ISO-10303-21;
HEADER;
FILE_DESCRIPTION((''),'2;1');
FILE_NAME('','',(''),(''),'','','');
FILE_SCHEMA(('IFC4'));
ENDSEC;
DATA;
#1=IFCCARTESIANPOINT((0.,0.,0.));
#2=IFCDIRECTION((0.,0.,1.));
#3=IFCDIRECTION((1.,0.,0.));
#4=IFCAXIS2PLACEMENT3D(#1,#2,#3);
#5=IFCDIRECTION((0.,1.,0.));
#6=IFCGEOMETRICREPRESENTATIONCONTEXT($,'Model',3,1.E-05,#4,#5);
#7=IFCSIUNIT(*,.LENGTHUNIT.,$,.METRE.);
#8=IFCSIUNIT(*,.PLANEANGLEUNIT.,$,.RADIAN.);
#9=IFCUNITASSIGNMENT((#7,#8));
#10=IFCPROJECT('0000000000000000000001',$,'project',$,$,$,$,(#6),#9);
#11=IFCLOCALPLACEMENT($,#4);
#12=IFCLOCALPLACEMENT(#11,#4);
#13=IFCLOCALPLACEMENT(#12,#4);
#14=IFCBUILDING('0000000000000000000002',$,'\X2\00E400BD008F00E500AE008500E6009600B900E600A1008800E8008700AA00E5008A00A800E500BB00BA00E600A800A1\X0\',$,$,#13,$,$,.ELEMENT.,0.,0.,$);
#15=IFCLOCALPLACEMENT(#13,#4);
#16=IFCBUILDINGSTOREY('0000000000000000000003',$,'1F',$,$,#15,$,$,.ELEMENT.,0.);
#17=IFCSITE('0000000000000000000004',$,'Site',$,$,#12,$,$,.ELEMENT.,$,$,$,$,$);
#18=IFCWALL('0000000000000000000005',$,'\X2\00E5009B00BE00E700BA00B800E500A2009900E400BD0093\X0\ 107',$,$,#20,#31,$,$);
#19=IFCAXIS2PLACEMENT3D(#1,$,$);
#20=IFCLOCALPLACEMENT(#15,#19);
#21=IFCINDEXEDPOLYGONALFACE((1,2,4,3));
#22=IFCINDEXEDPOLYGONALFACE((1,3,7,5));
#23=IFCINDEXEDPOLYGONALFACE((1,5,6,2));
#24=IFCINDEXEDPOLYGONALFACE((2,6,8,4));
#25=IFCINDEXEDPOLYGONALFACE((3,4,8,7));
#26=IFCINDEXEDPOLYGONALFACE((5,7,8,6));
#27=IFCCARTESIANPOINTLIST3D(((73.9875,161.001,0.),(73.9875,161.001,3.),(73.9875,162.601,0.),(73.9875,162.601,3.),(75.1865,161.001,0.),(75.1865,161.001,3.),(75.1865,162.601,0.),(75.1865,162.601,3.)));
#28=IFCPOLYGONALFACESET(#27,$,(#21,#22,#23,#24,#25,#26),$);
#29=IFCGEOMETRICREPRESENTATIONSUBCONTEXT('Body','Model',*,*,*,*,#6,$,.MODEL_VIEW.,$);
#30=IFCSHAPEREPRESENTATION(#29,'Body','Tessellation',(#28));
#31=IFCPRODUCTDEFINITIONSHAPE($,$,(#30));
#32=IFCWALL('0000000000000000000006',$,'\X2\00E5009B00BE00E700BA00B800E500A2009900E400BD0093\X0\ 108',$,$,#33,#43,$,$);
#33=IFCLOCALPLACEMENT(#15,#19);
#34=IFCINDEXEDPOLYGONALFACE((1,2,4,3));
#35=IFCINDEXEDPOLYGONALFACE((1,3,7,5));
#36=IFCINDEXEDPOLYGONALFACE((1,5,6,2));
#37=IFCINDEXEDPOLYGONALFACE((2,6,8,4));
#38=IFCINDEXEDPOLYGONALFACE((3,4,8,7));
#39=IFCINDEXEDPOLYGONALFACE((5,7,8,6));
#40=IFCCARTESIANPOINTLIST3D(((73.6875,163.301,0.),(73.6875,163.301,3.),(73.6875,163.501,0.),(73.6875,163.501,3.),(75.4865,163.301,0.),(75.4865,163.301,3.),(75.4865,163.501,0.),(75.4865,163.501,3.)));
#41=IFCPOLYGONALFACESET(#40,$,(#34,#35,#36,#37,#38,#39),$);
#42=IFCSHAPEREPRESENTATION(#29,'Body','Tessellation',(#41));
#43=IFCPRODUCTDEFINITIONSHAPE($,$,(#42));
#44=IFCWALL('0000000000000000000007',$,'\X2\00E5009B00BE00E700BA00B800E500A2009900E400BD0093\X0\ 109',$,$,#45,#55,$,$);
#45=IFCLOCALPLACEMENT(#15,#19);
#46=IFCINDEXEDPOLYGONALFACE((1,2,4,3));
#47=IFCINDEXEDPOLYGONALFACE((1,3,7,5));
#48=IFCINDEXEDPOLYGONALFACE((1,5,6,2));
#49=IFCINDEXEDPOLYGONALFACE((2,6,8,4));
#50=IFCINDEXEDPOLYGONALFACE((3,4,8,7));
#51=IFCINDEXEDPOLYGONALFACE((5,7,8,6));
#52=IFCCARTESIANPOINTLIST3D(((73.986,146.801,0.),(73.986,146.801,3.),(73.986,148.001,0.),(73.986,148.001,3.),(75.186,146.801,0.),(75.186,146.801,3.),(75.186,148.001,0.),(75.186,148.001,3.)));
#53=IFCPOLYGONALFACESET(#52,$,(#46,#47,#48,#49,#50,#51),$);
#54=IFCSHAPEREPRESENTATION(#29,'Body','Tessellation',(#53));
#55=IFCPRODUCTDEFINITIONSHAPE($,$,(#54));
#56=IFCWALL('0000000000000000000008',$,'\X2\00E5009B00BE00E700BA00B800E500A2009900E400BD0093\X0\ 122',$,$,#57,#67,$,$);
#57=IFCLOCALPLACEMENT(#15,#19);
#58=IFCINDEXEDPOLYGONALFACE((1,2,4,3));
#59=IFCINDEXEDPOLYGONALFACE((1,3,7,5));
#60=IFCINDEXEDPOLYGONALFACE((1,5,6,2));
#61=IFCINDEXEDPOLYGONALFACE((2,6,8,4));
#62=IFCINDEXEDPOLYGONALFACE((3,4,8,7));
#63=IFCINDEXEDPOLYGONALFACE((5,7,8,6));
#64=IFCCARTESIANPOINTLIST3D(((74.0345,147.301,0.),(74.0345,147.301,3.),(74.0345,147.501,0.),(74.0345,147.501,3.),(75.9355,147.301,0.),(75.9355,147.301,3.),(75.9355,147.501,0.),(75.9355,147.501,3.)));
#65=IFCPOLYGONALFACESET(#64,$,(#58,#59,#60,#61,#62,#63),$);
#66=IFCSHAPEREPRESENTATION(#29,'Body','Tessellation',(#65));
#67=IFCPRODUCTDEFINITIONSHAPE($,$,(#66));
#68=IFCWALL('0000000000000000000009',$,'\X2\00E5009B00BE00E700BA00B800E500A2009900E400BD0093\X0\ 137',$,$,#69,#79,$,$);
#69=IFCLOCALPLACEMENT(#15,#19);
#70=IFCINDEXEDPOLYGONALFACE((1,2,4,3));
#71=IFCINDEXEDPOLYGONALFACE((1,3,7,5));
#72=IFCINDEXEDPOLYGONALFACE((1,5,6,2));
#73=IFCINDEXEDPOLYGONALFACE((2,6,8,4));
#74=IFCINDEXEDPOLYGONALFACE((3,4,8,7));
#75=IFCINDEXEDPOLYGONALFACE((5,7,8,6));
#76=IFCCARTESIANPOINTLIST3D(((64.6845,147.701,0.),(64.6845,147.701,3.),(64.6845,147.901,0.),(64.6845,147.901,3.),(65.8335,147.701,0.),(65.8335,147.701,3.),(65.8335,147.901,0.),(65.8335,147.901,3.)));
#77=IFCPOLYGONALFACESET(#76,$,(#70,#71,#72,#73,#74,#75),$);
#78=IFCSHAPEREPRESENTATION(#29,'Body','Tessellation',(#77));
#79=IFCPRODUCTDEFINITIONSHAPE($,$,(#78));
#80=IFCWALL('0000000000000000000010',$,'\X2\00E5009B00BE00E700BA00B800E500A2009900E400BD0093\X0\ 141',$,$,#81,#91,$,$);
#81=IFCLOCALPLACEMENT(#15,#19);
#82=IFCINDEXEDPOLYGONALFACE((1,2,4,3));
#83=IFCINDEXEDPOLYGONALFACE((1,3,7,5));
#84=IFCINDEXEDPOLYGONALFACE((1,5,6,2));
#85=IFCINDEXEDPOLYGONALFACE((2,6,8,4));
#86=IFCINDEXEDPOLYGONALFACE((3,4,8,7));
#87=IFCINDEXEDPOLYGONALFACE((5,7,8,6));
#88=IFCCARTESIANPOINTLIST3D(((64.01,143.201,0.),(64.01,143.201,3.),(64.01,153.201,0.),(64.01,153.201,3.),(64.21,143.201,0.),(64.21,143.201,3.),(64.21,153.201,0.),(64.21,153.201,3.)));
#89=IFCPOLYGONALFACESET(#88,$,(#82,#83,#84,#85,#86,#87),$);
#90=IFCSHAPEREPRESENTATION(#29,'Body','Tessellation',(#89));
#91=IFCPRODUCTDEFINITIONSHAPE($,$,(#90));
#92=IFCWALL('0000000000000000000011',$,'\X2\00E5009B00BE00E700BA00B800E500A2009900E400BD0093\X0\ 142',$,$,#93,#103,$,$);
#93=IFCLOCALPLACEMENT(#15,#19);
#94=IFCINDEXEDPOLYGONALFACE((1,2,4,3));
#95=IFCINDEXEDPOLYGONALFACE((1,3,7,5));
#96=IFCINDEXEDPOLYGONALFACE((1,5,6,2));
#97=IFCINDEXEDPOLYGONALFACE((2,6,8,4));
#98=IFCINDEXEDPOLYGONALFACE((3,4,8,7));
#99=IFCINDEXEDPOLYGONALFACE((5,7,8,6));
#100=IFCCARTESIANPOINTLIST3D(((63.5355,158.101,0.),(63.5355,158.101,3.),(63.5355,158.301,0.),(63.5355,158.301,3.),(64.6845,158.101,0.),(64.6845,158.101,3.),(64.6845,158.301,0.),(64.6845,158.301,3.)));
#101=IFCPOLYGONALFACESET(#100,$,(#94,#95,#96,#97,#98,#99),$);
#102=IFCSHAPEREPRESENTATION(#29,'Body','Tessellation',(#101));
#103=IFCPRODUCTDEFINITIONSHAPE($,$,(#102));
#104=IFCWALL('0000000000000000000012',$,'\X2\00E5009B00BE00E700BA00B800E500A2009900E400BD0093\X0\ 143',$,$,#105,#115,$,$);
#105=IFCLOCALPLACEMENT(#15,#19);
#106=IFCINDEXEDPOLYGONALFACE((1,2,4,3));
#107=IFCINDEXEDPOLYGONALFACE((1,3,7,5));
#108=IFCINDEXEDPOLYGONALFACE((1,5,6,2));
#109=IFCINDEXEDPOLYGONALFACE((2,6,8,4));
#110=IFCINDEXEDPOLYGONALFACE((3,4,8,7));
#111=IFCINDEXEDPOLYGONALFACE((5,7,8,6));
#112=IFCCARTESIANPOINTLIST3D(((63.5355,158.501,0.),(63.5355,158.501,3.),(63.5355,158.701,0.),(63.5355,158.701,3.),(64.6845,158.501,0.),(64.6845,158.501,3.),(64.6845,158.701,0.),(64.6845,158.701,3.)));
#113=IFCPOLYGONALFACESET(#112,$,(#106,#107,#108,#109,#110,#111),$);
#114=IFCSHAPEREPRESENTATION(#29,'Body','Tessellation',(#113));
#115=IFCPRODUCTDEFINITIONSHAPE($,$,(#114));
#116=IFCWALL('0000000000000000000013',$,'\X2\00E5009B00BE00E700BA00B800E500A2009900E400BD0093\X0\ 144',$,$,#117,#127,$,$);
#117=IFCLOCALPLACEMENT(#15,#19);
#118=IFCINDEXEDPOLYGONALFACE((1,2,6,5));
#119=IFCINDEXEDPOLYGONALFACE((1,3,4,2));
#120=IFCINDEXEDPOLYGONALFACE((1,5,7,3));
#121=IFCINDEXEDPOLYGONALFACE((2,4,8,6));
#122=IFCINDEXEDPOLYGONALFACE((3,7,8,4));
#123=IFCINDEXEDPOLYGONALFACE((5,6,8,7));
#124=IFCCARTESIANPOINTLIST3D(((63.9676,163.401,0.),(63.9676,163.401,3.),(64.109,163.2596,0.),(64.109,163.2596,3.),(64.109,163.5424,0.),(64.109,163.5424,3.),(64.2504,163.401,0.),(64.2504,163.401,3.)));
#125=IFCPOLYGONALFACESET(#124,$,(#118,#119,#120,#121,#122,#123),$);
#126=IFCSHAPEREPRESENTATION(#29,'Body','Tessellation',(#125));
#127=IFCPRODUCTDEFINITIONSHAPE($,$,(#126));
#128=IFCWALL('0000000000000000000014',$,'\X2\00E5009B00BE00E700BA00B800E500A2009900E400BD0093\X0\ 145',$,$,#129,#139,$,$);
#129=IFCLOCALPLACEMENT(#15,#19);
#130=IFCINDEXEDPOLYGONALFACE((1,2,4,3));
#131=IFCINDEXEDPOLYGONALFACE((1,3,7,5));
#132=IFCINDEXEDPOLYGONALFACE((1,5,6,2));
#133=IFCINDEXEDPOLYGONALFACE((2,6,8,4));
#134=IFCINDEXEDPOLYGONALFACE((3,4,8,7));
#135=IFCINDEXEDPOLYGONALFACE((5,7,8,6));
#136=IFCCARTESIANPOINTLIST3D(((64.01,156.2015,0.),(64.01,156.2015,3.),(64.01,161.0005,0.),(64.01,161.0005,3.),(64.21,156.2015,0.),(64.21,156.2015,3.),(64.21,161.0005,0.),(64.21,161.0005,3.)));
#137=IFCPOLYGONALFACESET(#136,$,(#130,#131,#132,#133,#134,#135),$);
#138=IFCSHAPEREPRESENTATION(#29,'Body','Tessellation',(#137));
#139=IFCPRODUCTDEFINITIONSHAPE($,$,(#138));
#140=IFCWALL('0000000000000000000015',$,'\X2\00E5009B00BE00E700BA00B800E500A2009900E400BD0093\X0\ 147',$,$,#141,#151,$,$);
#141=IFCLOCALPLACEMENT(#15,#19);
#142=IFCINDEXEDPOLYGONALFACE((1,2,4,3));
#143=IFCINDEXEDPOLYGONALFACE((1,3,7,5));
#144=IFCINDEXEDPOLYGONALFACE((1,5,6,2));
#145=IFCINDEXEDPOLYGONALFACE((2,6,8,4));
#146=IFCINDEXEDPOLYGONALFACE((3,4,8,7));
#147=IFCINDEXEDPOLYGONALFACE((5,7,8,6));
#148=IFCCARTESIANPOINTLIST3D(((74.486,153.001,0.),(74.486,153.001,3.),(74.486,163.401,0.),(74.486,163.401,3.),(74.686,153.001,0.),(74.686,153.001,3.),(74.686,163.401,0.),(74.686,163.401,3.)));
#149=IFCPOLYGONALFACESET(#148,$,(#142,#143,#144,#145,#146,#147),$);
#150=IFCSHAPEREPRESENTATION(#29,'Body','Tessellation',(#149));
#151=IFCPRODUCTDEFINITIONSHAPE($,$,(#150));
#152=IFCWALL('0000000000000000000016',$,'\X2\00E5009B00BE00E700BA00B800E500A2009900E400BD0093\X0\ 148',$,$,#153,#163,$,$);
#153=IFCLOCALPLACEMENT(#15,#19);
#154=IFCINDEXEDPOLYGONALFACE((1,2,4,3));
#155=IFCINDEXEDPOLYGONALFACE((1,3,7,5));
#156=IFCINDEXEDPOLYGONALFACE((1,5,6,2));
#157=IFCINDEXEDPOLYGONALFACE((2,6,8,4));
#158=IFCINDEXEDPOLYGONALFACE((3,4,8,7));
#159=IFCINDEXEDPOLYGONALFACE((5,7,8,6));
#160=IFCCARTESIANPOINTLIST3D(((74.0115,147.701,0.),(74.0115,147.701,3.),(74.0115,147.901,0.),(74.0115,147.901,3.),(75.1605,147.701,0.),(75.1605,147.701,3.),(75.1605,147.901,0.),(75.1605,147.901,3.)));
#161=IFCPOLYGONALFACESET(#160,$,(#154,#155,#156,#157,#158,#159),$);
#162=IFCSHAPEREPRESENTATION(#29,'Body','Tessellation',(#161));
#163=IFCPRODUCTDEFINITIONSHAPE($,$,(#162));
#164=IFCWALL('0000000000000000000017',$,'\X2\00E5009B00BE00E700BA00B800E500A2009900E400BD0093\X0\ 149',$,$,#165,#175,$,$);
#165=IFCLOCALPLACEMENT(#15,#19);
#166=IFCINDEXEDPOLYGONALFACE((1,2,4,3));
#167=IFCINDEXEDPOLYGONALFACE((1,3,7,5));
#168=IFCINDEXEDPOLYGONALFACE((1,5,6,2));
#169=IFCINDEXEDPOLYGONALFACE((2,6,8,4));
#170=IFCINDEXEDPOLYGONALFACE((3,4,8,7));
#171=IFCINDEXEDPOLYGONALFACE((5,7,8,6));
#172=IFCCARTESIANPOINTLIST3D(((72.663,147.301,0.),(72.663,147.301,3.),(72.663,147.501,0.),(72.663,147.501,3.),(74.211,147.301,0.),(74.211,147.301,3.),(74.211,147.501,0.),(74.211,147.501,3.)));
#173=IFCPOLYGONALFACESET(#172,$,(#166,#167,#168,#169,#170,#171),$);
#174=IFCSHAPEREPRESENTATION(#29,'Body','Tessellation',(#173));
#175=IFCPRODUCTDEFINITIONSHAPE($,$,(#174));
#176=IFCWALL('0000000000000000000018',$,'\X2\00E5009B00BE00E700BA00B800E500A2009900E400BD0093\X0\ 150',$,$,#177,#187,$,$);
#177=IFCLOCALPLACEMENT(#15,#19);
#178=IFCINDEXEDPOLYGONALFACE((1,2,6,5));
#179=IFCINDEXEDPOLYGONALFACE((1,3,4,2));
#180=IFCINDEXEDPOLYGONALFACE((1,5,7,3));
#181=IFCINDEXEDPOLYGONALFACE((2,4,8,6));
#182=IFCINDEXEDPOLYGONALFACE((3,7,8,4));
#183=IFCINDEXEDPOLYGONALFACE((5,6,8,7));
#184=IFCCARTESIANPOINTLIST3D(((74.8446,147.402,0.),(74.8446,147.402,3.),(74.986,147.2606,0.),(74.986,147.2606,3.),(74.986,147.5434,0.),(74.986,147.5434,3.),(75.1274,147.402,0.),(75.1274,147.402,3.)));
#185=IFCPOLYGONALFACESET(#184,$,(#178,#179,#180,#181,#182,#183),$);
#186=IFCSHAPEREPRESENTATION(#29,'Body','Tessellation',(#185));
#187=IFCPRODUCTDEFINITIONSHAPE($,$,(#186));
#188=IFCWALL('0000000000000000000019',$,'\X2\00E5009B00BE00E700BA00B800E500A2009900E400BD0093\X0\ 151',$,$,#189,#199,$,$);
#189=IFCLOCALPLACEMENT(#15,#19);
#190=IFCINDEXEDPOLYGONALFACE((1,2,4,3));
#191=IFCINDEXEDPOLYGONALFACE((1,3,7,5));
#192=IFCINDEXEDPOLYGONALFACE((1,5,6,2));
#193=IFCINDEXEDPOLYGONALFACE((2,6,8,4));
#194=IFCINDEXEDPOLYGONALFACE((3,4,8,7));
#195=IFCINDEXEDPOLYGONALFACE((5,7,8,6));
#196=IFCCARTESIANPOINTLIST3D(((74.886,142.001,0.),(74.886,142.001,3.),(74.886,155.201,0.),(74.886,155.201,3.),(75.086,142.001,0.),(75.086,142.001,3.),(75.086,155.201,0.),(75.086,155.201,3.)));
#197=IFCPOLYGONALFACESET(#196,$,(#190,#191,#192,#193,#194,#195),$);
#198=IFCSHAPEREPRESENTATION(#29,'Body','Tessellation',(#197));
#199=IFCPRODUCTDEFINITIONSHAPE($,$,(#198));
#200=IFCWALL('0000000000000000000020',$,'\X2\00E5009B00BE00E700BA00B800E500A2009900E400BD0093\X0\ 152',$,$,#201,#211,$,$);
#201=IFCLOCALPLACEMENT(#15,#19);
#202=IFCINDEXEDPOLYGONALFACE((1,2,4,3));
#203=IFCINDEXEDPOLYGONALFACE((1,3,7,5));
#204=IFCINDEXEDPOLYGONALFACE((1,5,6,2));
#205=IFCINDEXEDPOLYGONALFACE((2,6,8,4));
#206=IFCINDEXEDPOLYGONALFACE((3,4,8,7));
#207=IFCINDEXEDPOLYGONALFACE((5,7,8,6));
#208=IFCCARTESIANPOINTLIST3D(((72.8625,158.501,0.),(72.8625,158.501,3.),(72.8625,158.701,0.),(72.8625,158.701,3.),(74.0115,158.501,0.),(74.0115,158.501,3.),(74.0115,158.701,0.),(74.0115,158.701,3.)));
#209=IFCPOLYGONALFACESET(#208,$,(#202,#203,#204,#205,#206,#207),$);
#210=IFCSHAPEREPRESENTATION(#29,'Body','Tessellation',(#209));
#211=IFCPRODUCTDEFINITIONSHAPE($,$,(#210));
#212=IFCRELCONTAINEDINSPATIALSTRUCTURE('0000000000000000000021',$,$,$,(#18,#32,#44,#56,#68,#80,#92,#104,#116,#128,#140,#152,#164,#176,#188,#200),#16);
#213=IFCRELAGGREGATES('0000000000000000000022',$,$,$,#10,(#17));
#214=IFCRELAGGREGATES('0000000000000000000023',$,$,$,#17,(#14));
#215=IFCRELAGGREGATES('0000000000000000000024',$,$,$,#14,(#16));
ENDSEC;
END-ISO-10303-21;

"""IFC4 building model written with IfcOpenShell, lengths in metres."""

from ifc_helpers import new_model, si_unit, direction, frame, frame_2d, origin_with_axes, place, context, subcontext, project, spatial, rectangle, extrude, element, save


model = new_model("IFC4")

# Units and contexts
model_context = context("Model", 3, precision=1e-05, world=origin_with_axes(), true_north=direction((0.0, 1.0, 0.0)))
body_context = subcontext(model_context, "Body", "Model", "MODEL_VIEW")
ifc_project = project(units=[si_unit("LENGTHUNIT", "METRE"), si_unit("PLANEANGLEUNIT", "RADIAN")], contexts=[model_context])

# Site, building, storey
placement = place(None, origin_with_axes())
site_placement = place(placement, origin_with_axes())
site = spatial("IfcSite", under=ifc_project, at=site_placement, Name="Site", CompositionType="ELEMENT")
building_placement = place(site_placement, origin_with_axes())
building = spatial("IfcBuilding", under=site, at=building_placement, Name="ä½\u008få®\u0085æ\u0096¹æ¡\u0088è\u0087ªå\u008a¨å»ºæ¨¡", CompositionType="ELEMENT", ElevationOfRefHeight=0.0, ElevationOfTerrain=0.0)
storey_placement = place(building_placement, origin_with_axes())
storey = spatial("IfcBuildingStorey", under=building, at=storey_placement, Name="1F", CompositionType="ELEMENT", Elevation=0.0)

# Walls
wall_1_placement = place(storey_placement, frame((74.587, 161.801, 0.0), z_axis=(0.0, 0.0, 1.0), x_axis=(1.0, 0.0, 0.0)))
element("IfcWall", 1, at=wall_1_placement, inside=storey, Name="å\u009b¾çº¸å¢\u0099ä½\u0093 107", context=body_context, shape_type="SweptSolid", body=[
    extrude(rectangle(XDim=1.199, YDim=1.6, at=frame_2d((0.0, 0.0), x_axis=(1.0, 0.0, 0.0))), frame((0.0, 0.0, 0.0), z_axis=(0.0, 0.0, 1.0)), (0.0, 0.0, 1.0), 3.0),
])
wall_2_placement = place(storey_placement, frame((74.587, 163.401, 0.0), z_axis=(0.0, 0.0, 1.0), x_axis=(1.0, 0.0, 0.0)))
element("IfcWall", 2, at=wall_2_placement, inside=storey, Name="å\u009b¾çº¸å¢\u0099ä½\u0093 108", context=body_context, shape_type="SweptSolid", body=[
    extrude(rectangle(XDim=1.799, YDim=0.2, at=frame_2d((0.0, 0.0), x_axis=(1.0, 0.0, 0.0))), frame((0.0, 0.0, 0.0), z_axis=(0.0, 0.0, 1.0)), (0.0, 0.0, 1.0), 3.0),
])
wall_3_placement = place(storey_placement, frame((74.586, 147.401, 0.0), z_axis=(0.0, 0.0, 1.0), x_axis=(1.0, 0.0, 0.0)))
element("IfcWall", 3, at=wall_3_placement, inside=storey, Name="å\u009b¾çº¸å¢\u0099ä½\u0093 109", context=body_context, shape_type="SweptSolid", body=[
    extrude(rectangle(XDim=1.2, YDim=1.2, at=frame_2d((0.0, 0.0), x_axis=(1.0, 0.0, 0.0))), frame((0.0, 0.0, 0.0), z_axis=(0.0, 0.0, 1.0)), (0.0, 0.0, 1.0), 3.0),
])
wall_4_placement = place(storey_placement, frame((74.985, 147.401, 0.0), z_axis=(0.0, 0.0, 1.0), x_axis=(1.0, 0.0, 0.0)))
element("IfcWall", 4, at=wall_4_placement, inside=storey, Name="å\u009b¾çº¸å¢\u0099ä½\u0093 122", context=body_context, shape_type="SweptSolid", body=[
    extrude(rectangle(XDim=1.901, YDim=0.2, at=frame_2d((0.0, 0.0), x_axis=(1.0, 0.0, 0.0))), frame((0.0, 0.0, 0.0), z_axis=(0.0, 0.0, 1.0)), (0.0, 0.0, 1.0), 3.0),
])
wall_5_placement = place(storey_placement, frame((65.259, 147.801, 0.0), z_axis=(0.0, 0.0, 1.0), x_axis=(-1.0, 0.0, 0.0)))
element("IfcWall", 5, at=wall_5_placement, inside=storey, Name="å\u009b¾çº¸å¢\u0099ä½\u0093 137", context=body_context, shape_type="SweptSolid", body=[
    extrude(rectangle(XDim=1.149, YDim=0.2, at=frame_2d((0.0, 0.0), x_axis=(1.0, 0.0, 0.0))), frame((0.0, 0.0, 0.0), z_axis=(0.0, 0.0, 1.0)), (0.0, 0.0, 1.0), 3.0),
])
wall_6_placement = place(storey_placement, frame((64.11, 148.201, 0.0), z_axis=(0.0, 0.0, 1.0), x_axis=(0.0, 1.0, 0.0)))
element("IfcWall", 6, at=wall_6_placement, inside=storey, Name="å\u009b¾çº¸å¢\u0099ä½\u0093 141", context=body_context, shape_type="SweptSolid", body=[
    extrude(rectangle(XDim=10.0, YDim=0.2, at=frame_2d((0.0, 0.0), x_axis=(1.0, 0.0, 0.0))), frame((0.0, 0.0, 0.0), z_axis=(0.0, 0.0, 1.0)), (0.0, 0.0, 1.0), 3.0),
])
for number, where, z_axis, x_axis, name in (
    (7, (64.11, 158.201, 0.0), (0.0, 0.0, 1.0), (1.0, 0.0, 0.0), "å\u009b¾çº¸å¢\u0099ä½\u0093 142"),
    (8, (64.11, 158.601, 0.0), (0.0, 0.0, 1.0), (1.0, 0.0, 0.0), "å\u009b¾çº¸å¢\u0099ä½\u0093 143"),
):
    element("IfcWall", number, at=place(storey_placement, frame(where, z_axis=z_axis, x_axis=x_axis)), inside=storey, Name=name, context=body_context, shape_type="SweptSolid", body=[
        extrude(rectangle(XDim=1.149, YDim=0.2, at=frame_2d((0.0, 0.0), x_axis=(1.0, 0.0, 0.0))), frame((0.0, 0.0, 0.0), z_axis=(0.0, 0.0, 1.0)), (0.0, 0.0, 1.0), 3.0),
    ])
wall_7_placement = place(storey_placement, frame((64.109, 163.401, 0.0), z_axis=(0.0, 0.0, 1.0), x_axis=(0.707107, -0.707107, 0.0)))
element("IfcWall", 9, at=wall_7_placement, inside=storey, Name="å\u009b¾çº¸å¢\u0099ä½\u0093 144", context=body_context, shape_type="SweptSolid", body=[
    extrude(rectangle(XDim=0.2, YDim=0.2, at=frame_2d((0.0, 0.0), x_axis=(1.0, 0.0, 0.0))), frame((0.0, 0.0, 0.0), z_axis=(0.0, 0.0, 1.0)), (0.0, 0.0, 1.0), 3.0),
])
wall_8_placement = place(storey_placement, frame((64.11, 158.601, 0.0), z_axis=(0.0, 0.0, 1.0), x_axis=(0.0, 1.0, 0.0)))
element("IfcWall", 10, at=wall_8_placement, inside=storey, Name="å\u009b¾çº¸å¢\u0099ä½\u0093 145", context=body_context, shape_type="SweptSolid", body=[
    extrude(rectangle(XDim=4.799, YDim=0.2, at=frame_2d((0.0, 0.0), x_axis=(1.0, 0.0, 0.0))), frame((0.0, 0.0, 0.0), z_axis=(0.0, 0.0, 1.0)), (0.0, 0.0, 1.0), 3.0),
])
wall_9_placement = place(storey_placement, frame((74.586, 158.201, 0.0), z_axis=(0.0, 0.0, 1.0), x_axis=(0.0, -1.0, 0.0)))
element("IfcWall", 11, at=wall_9_placement, inside=storey, Name="å\u009b¾çº¸å¢\u0099ä½\u0093 147", context=body_context, shape_type="SweptSolid", body=[
    extrude(rectangle(XDim=10.4, YDim=0.2, at=frame_2d((0.0, 0.0), x_axis=(1.0, 0.0, 0.0))), frame((0.0, 0.0, 0.0), z_axis=(0.0, 0.0, 1.0)), (0.0, 0.0, 1.0), 3.0),
])
wall_10_placement = place(storey_placement, frame((74.586, 147.801, 0.0), z_axis=(0.0, 0.0, 1.0), x_axis=(-1.0, 0.0, 0.0)))
element("IfcWall", 12, at=wall_10_placement, inside=storey, Name="å\u009b¾çº¸å¢\u0099ä½\u0093 148", context=body_context, shape_type="SweptSolid", body=[
    extrude(rectangle(XDim=1.149, YDim=0.2, at=frame_2d((0.0, 0.0), x_axis=(1.0, 0.0, 0.0))), frame((0.0, 0.0, 0.0), z_axis=(0.0, 0.0, 1.0)), (0.0, 0.0, 1.0), 3.0),
])
wall_11_placement = place(storey_placement, frame((73.437, 147.401, 0.0), z_axis=(0.0, 0.0, 1.0), x_axis=(1.0, 0.0, 0.0)))
element("IfcWall", 13, at=wall_11_placement, inside=storey, Name="å\u009b¾çº¸å¢\u0099ä½\u0093 149", context=body_context, shape_type="SweptSolid", body=[
    extrude(rectangle(XDim=1.548, YDim=0.2, at=frame_2d((0.0, 0.0), x_axis=(1.0, 0.0, 0.0))), frame((0.0, 0.0, 0.0), z_axis=(0.0, 0.0, 1.0)), (0.0, 0.0, 1.0), 3.0),
])
wall_12_placement = place(storey_placement, frame((74.986, 147.402, 0.0), z_axis=(0.0, 0.0, 1.0), x_axis=(-0.707107, -0.707107, 0.0)))
element("IfcWall", 14, at=wall_12_placement, inside=storey, Name="å\u009b¾çº¸å¢\u0099ä½\u0093 150", context=body_context, shape_type="SweptSolid", body=[
    extrude(rectangle(XDim=0.2, YDim=0.2, at=frame_2d((0.0, 0.0), x_axis=(1.0, 0.0, 0.0))), frame((0.0, 0.0, 0.0), z_axis=(0.0, 0.0, 1.0)), (0.0, 0.0, 1.0), 3.0),
])
wall_13_placement = place(storey_placement, frame((74.986, 148.601, 0.0), z_axis=(0.0, 0.0, 1.0), x_axis=(0.0, 1.0, 0.0)))
element("IfcWall", 15, at=wall_13_placement, inside=storey, Name="å\u009b¾çº¸å¢\u0099ä½\u0093 151", context=body_context, shape_type="SweptSolid", body=[
    extrude(rectangle(XDim=13.2, YDim=0.2, at=frame_2d((0.0, 0.0), x_axis=(1.0, 0.0, 0.0))), frame((0.0, 0.0, 0.0), z_axis=(0.0, 0.0, 1.0)), (0.0, 0.0, 1.0), 3.0),
])
for number, where, z_axis, x_axis, name in (
    (16, (73.437, 158.601, 0.0), (0.0, 0.0, 1.0), (1.0, 0.0, 0.0), "å\u009b¾çº¸å¢\u0099ä½\u0093 152"),
):
    element("IfcWall", number, at=place(storey_placement, frame(where, z_axis=z_axis, x_axis=x_axis)), inside=storey, Name=name, context=body_context, shape_type="SweptSolid", body=[
        extrude(rectangle(XDim=1.149, YDim=0.2, at=frame_2d((0.0, 0.0), x_axis=(1.0, 0.0, 0.0))), frame((0.0, 0.0, 0.0), z_axis=(0.0, 0.0, 1.0)), (0.0, 0.0, 1.0), 3.0),
    ])

save(model, "model.ifc")
